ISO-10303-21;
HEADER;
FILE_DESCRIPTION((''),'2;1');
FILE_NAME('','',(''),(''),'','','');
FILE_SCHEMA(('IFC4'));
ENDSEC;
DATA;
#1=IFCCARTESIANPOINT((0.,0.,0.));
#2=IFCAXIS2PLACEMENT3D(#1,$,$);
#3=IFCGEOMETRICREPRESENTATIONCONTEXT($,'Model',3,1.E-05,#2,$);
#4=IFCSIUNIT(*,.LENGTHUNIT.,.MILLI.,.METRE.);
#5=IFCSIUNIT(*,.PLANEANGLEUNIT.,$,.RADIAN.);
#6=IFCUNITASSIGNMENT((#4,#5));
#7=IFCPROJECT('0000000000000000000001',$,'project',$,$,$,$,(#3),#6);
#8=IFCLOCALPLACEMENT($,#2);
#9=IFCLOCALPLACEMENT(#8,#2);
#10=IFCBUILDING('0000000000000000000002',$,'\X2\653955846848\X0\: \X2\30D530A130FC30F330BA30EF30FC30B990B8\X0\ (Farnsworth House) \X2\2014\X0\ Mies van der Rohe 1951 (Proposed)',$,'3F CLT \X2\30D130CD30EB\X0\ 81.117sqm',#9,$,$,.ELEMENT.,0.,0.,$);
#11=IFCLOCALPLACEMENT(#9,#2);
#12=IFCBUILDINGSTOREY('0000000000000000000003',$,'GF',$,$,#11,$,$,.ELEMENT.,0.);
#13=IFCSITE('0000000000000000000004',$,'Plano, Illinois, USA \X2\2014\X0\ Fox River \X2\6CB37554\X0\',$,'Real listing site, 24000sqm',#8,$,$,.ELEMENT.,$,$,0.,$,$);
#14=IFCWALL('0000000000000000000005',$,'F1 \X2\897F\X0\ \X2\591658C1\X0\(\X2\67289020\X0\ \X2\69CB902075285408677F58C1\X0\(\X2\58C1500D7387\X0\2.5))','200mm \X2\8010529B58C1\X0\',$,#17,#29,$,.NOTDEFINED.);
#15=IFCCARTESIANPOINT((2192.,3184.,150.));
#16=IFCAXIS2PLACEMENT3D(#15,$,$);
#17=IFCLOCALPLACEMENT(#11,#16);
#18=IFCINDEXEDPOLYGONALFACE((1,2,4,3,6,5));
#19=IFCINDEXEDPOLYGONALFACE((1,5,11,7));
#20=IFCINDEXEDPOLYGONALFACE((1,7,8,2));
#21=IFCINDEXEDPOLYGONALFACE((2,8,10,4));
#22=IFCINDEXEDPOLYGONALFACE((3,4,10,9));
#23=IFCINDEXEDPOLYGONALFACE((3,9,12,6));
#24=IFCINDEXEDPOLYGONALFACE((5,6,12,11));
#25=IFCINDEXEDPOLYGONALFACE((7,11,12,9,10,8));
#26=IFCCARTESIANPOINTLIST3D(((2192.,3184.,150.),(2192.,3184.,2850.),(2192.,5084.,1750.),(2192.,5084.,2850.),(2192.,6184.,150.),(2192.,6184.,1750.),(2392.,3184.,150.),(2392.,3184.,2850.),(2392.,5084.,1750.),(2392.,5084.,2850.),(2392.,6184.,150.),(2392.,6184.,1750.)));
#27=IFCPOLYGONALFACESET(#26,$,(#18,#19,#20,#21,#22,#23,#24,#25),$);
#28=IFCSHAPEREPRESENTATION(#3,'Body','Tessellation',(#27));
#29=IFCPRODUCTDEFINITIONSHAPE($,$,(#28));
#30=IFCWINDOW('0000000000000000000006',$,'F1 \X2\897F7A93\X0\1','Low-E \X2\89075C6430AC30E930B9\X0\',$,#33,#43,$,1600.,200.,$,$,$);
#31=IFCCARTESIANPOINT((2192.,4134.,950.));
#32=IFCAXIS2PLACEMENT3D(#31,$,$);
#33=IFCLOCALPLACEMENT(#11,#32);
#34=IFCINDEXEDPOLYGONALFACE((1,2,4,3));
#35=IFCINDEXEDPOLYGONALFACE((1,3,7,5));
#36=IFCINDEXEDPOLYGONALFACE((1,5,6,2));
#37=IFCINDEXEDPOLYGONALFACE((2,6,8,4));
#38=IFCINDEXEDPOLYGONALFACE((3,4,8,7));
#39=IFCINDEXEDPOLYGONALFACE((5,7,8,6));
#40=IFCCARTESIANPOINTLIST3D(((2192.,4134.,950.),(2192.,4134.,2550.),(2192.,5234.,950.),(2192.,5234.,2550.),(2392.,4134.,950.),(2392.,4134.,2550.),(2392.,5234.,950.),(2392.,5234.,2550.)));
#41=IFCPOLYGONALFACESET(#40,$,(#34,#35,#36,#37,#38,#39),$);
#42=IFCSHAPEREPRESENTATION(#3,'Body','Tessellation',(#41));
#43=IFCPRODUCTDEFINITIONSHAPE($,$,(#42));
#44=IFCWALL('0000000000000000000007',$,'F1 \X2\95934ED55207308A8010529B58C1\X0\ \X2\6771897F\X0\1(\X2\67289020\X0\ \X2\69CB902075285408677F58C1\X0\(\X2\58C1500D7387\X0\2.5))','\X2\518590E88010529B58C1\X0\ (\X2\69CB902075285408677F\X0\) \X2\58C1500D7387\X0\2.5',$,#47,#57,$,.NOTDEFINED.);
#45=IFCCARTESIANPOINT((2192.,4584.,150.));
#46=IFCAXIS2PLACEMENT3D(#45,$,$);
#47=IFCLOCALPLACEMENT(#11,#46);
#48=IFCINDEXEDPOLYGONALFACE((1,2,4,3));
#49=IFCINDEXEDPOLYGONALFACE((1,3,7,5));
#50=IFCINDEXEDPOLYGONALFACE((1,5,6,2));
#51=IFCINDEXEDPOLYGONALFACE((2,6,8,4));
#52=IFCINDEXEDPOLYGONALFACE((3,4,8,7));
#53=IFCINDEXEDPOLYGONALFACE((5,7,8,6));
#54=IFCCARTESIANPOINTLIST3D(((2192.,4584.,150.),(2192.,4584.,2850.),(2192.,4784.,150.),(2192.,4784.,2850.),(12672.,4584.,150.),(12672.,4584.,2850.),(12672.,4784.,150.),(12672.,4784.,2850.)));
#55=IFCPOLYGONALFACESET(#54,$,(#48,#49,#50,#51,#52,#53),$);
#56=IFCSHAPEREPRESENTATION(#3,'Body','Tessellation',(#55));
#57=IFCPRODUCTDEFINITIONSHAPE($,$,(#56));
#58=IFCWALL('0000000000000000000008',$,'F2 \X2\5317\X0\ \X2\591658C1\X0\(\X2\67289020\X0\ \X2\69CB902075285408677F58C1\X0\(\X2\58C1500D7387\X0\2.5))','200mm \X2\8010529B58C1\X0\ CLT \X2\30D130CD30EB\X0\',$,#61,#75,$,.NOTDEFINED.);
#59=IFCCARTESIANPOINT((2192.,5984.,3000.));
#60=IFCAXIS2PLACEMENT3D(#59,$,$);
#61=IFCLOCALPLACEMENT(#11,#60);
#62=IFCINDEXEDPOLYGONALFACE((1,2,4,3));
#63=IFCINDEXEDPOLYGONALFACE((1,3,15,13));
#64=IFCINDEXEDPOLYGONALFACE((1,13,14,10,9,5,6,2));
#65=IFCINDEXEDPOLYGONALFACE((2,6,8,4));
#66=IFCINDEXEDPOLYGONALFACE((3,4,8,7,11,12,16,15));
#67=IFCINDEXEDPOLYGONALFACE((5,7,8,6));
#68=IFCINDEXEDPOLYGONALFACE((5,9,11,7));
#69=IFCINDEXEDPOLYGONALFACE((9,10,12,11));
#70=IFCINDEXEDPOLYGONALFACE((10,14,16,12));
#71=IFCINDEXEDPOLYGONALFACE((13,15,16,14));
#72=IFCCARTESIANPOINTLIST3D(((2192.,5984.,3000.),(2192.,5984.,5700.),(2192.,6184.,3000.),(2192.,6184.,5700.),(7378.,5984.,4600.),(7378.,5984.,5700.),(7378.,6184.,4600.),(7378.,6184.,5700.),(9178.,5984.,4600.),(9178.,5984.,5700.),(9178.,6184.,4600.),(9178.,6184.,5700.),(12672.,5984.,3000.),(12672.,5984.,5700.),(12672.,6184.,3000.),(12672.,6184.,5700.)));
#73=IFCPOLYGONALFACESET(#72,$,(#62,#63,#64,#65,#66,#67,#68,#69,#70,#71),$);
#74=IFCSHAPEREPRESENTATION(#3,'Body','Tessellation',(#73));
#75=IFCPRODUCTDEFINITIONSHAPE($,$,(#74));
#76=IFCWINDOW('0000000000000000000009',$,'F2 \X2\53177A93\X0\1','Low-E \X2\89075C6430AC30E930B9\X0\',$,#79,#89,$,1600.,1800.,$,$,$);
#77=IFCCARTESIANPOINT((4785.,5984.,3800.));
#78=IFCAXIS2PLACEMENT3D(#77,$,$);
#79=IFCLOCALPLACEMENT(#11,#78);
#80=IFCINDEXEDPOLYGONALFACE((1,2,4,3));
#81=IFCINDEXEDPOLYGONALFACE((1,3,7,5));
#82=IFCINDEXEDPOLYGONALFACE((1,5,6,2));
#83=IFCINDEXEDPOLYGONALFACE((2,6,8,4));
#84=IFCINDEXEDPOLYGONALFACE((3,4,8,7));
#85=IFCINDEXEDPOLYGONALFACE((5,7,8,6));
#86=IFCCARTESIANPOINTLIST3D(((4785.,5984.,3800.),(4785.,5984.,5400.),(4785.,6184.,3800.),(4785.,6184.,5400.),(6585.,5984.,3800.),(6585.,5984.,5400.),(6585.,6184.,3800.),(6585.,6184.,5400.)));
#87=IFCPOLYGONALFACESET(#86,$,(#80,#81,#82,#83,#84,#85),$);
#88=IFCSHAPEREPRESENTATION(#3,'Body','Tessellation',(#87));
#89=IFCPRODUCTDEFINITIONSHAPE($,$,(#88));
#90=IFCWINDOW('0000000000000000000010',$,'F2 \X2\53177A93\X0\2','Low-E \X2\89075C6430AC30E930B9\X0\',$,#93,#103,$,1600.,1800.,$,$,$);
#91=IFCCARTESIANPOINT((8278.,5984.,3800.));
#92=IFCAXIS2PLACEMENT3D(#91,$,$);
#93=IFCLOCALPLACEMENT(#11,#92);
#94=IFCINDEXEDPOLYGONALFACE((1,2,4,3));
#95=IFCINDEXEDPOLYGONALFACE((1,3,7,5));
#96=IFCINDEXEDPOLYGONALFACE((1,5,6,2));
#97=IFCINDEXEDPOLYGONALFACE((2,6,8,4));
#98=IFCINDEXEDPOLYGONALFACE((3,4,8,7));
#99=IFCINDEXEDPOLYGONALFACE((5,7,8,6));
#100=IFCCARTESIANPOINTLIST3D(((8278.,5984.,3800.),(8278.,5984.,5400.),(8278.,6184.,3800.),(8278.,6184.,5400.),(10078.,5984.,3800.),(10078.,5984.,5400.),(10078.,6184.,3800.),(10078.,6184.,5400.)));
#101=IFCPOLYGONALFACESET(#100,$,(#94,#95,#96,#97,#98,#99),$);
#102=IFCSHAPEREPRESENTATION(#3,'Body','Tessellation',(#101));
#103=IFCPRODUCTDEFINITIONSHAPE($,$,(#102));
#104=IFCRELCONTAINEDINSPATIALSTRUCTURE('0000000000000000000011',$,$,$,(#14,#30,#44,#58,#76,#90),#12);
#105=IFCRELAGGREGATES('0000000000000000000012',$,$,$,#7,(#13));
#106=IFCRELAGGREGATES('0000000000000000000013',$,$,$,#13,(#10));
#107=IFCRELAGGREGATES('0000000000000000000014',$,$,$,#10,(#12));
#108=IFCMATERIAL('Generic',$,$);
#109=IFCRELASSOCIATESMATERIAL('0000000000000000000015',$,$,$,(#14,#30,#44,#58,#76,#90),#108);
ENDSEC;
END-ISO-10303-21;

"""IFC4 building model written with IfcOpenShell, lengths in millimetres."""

from ifc_helpers import new_model, si_unit, frame, frame_2d, origin, place, context, project, spatial, rectangle, extrude, material, element, fill, save


model = new_model("IFC4")

# Units and contexts
model_context = context("Model", 3, precision=1e-05, world=origin())
ifc_project = project(units=[si_unit("LENGTHUNIT", "METRE", prefix="MILLI"), si_unit("PLANEANGLEUNIT", "RADIAN")], contexts=[model_context])

# Site, building, storey
site_placement = place(None, origin())
site = spatial("IfcSite", under=ifc_project, at=site_placement, Name="Plano, Illinois, USA — Fox River 河畔", ObjectType="Real listing site, 24000sqm", CompositionType="ELEMENT", RefElevation=0.0)
building_placement = place(site_placement, origin())
building = spatial("IfcBuilding", under=site, at=building_placement, Name="改善案: ファーンズワース邸 (Farnsworth House) — Mies van der Rohe 1951 (Proposed)", ObjectType="3F CLT パネル 81.117sqm", CompositionType="ELEMENT", ElevationOfRefHeight=0.0, ElevationOfTerrain=0.0)
storey_placement = place(building_placement, origin())
storey = spatial("IfcBuildingStorey", under=building, at=storey_placement, Name="GF", CompositionType="ELEMENT", Elevation=0.0)

# Shared definitions
ifc_material_1 = material(Name="Generic")

# Wall, opening, window
wall_1_placement = place(storey_placement, frame((2192.0, 3184.0, 150.0)))
wall_1 = element("IfcWall", 1, at=wall_1_placement, inside=storey, material=ifc_material_1, Name="F1 西 外壁(木造 構造用合板壁(壁倍率2.5))", Description="200mm 耐力壁", PredefinedType="NOTDEFINED", context=model_context, shape_type="SweptSolid", body=[
    extrude(rectangle(XDim=200.0, YDim=3000.0, at=frame_2d((100.0, 1500.0))), frame((2192.0, 3184.0, 150.0)), (0.0, 0.0, 1.0), 2700.0),
])
opening_1_placement = place(storey_placement, frame((2192.0, 4134.0, 950.0)))
opening_1 = element("IfcOpeningElement", 2, at=opening_1_placement, cuts=wall_1, PredefinedType="NOTDEFINED", context=model_context, shape_type="SweptSolid", body=[
    extrude(rectangle(XDim=200.0, YDim=1100.0, at=frame_2d((100.0, 550.0))), frame((2192.0, 4134.0, 950.0)), (0.0, 0.0, 1.0), 1600.0),
])
window_1_placement = place(storey_placement, frame((2192.0, 4134.0, 950.0)))
window_1 = element("IfcWindow", 3, at=window_1_placement, inside=storey, material=ifc_material_1, Name="F1 西窓1", Description="Low-E 複層ガラス", OverallHeight=1600.0, OverallWidth=200.0, context=model_context, shape_type="SweptSolid", body=[
    extrude(rectangle(XDim=200.0, YDim=1100.0, at=frame_2d((100.0, 550.0))), frame((2192.0, 4134.0, 950.0)), (0.0, 0.0, 1.0), 1600.0),
])
fill(opening_1, window_1)

# Wall
wall_2_placement = place(storey_placement, frame((2192.0, 4584.0, 150.0)))
element("IfcWall", 4, at=wall_2_placement, inside=storey, material=ifc_material_1, Name="F1 間仕切り耐力壁 東西1(木造 構造用合板壁(壁倍率2.5))", Description="内部耐力壁 (構造用合板) 壁倍率2.5", PredefinedType="NOTDEFINED", context=model_context, shape_type="SweptSolid", body=[
    extrude(rectangle(XDim=10480.0, YDim=200.0, at=frame_2d((5240.0, 100.0))), frame((2192.0, 4584.0, 150.0)), (0.0, 0.0, 1.0), 2700.0),
])

# Wall, openings, windows
wall_3_placement = place(storey_placement, frame((2192.0, 5984.0, 3000.0)))
wall_3 = element("IfcWall", 5, at=wall_3_placement, inside=storey, material=ifc_material_1, Name="F2 北 外壁(木造 構造用合板壁(壁倍率2.5))", Description="200mm 耐力壁 CLT パネル", PredefinedType="NOTDEFINED", context=model_context, shape_type="SweptSolid", body=[
    extrude(rectangle(XDim=10480.0, YDim=200.0, at=frame_2d((5240.0, 100.0))), frame((2192.0, 5984.0, 3000.0)), (0.0, 0.0, 1.0), 2700.0),
])
opening_2_placement = place(storey_placement, frame((4785.0, 5984.0, 3800.0)))
opening_2 = element("IfcOpeningElement", 6, at=opening_2_placement, cuts=wall_3, PredefinedType="NOTDEFINED", context=model_context, shape_type="SweptSolid", body=[
    extrude(rectangle(XDim=1800.0, YDim=200.0, at=frame_2d((900.0, 100.0))), frame((4785.0, 5984.0, 3800.0)), (0.0, 0.0, 1.0), 1600.0),
])
opening_3_placement = place(storey_placement, frame((8278.0, 5984.0, 3800.0)))
opening_3 = element("IfcOpeningElement", 7, at=opening_3_placement, cuts=wall_3, PredefinedType="NOTDEFINED", context=model_context, shape_type="SweptSolid", body=[
    extrude(rectangle(XDim=1800.0, YDim=200.0, at=frame_2d((900.0, 100.0))), frame((8278.0, 5984.0, 3800.0)), (0.0, 0.0, 1.0), 1600.0),
])
window_2_placement = place(storey_placement, frame((4785.0, 5984.0, 3800.0)))
window_2 = element("IfcWindow", 8, at=window_2_placement, inside=storey, material=ifc_material_1, Name="F2 北窓1", Description="Low-E 複層ガラス", OverallHeight=1600.0, OverallWidth=1800.0, context=model_context, shape_type="SweptSolid", body=[
    extrude(rectangle(XDim=1800.0, YDim=200.0, at=frame_2d((900.0, 100.0))), frame((4785.0, 5984.0, 3800.0)), (0.0, 0.0, 1.0), 1600.0),
])
fill(opening_2, window_2)
window_3_placement = place(storey_placement, frame((8278.0, 5984.0, 3800.0)))
window_3 = element("IfcWindow", 9, at=window_3_placement, inside=storey, material=ifc_material_1, Name="F2 北窓2", Description="Low-E 複層ガラス", OverallHeight=1600.0, OverallWidth=1800.0, context=model_context, shape_type="SweptSolid", body=[
    extrude(rectangle(XDim=1800.0, YDim=200.0, at=frame_2d((900.0, 100.0))), frame((8278.0, 5984.0, 3800.0)), (0.0, 0.0, 1.0), 1600.0),
])
fill(opening_3, window_3)

save(model, "model.ifc")
